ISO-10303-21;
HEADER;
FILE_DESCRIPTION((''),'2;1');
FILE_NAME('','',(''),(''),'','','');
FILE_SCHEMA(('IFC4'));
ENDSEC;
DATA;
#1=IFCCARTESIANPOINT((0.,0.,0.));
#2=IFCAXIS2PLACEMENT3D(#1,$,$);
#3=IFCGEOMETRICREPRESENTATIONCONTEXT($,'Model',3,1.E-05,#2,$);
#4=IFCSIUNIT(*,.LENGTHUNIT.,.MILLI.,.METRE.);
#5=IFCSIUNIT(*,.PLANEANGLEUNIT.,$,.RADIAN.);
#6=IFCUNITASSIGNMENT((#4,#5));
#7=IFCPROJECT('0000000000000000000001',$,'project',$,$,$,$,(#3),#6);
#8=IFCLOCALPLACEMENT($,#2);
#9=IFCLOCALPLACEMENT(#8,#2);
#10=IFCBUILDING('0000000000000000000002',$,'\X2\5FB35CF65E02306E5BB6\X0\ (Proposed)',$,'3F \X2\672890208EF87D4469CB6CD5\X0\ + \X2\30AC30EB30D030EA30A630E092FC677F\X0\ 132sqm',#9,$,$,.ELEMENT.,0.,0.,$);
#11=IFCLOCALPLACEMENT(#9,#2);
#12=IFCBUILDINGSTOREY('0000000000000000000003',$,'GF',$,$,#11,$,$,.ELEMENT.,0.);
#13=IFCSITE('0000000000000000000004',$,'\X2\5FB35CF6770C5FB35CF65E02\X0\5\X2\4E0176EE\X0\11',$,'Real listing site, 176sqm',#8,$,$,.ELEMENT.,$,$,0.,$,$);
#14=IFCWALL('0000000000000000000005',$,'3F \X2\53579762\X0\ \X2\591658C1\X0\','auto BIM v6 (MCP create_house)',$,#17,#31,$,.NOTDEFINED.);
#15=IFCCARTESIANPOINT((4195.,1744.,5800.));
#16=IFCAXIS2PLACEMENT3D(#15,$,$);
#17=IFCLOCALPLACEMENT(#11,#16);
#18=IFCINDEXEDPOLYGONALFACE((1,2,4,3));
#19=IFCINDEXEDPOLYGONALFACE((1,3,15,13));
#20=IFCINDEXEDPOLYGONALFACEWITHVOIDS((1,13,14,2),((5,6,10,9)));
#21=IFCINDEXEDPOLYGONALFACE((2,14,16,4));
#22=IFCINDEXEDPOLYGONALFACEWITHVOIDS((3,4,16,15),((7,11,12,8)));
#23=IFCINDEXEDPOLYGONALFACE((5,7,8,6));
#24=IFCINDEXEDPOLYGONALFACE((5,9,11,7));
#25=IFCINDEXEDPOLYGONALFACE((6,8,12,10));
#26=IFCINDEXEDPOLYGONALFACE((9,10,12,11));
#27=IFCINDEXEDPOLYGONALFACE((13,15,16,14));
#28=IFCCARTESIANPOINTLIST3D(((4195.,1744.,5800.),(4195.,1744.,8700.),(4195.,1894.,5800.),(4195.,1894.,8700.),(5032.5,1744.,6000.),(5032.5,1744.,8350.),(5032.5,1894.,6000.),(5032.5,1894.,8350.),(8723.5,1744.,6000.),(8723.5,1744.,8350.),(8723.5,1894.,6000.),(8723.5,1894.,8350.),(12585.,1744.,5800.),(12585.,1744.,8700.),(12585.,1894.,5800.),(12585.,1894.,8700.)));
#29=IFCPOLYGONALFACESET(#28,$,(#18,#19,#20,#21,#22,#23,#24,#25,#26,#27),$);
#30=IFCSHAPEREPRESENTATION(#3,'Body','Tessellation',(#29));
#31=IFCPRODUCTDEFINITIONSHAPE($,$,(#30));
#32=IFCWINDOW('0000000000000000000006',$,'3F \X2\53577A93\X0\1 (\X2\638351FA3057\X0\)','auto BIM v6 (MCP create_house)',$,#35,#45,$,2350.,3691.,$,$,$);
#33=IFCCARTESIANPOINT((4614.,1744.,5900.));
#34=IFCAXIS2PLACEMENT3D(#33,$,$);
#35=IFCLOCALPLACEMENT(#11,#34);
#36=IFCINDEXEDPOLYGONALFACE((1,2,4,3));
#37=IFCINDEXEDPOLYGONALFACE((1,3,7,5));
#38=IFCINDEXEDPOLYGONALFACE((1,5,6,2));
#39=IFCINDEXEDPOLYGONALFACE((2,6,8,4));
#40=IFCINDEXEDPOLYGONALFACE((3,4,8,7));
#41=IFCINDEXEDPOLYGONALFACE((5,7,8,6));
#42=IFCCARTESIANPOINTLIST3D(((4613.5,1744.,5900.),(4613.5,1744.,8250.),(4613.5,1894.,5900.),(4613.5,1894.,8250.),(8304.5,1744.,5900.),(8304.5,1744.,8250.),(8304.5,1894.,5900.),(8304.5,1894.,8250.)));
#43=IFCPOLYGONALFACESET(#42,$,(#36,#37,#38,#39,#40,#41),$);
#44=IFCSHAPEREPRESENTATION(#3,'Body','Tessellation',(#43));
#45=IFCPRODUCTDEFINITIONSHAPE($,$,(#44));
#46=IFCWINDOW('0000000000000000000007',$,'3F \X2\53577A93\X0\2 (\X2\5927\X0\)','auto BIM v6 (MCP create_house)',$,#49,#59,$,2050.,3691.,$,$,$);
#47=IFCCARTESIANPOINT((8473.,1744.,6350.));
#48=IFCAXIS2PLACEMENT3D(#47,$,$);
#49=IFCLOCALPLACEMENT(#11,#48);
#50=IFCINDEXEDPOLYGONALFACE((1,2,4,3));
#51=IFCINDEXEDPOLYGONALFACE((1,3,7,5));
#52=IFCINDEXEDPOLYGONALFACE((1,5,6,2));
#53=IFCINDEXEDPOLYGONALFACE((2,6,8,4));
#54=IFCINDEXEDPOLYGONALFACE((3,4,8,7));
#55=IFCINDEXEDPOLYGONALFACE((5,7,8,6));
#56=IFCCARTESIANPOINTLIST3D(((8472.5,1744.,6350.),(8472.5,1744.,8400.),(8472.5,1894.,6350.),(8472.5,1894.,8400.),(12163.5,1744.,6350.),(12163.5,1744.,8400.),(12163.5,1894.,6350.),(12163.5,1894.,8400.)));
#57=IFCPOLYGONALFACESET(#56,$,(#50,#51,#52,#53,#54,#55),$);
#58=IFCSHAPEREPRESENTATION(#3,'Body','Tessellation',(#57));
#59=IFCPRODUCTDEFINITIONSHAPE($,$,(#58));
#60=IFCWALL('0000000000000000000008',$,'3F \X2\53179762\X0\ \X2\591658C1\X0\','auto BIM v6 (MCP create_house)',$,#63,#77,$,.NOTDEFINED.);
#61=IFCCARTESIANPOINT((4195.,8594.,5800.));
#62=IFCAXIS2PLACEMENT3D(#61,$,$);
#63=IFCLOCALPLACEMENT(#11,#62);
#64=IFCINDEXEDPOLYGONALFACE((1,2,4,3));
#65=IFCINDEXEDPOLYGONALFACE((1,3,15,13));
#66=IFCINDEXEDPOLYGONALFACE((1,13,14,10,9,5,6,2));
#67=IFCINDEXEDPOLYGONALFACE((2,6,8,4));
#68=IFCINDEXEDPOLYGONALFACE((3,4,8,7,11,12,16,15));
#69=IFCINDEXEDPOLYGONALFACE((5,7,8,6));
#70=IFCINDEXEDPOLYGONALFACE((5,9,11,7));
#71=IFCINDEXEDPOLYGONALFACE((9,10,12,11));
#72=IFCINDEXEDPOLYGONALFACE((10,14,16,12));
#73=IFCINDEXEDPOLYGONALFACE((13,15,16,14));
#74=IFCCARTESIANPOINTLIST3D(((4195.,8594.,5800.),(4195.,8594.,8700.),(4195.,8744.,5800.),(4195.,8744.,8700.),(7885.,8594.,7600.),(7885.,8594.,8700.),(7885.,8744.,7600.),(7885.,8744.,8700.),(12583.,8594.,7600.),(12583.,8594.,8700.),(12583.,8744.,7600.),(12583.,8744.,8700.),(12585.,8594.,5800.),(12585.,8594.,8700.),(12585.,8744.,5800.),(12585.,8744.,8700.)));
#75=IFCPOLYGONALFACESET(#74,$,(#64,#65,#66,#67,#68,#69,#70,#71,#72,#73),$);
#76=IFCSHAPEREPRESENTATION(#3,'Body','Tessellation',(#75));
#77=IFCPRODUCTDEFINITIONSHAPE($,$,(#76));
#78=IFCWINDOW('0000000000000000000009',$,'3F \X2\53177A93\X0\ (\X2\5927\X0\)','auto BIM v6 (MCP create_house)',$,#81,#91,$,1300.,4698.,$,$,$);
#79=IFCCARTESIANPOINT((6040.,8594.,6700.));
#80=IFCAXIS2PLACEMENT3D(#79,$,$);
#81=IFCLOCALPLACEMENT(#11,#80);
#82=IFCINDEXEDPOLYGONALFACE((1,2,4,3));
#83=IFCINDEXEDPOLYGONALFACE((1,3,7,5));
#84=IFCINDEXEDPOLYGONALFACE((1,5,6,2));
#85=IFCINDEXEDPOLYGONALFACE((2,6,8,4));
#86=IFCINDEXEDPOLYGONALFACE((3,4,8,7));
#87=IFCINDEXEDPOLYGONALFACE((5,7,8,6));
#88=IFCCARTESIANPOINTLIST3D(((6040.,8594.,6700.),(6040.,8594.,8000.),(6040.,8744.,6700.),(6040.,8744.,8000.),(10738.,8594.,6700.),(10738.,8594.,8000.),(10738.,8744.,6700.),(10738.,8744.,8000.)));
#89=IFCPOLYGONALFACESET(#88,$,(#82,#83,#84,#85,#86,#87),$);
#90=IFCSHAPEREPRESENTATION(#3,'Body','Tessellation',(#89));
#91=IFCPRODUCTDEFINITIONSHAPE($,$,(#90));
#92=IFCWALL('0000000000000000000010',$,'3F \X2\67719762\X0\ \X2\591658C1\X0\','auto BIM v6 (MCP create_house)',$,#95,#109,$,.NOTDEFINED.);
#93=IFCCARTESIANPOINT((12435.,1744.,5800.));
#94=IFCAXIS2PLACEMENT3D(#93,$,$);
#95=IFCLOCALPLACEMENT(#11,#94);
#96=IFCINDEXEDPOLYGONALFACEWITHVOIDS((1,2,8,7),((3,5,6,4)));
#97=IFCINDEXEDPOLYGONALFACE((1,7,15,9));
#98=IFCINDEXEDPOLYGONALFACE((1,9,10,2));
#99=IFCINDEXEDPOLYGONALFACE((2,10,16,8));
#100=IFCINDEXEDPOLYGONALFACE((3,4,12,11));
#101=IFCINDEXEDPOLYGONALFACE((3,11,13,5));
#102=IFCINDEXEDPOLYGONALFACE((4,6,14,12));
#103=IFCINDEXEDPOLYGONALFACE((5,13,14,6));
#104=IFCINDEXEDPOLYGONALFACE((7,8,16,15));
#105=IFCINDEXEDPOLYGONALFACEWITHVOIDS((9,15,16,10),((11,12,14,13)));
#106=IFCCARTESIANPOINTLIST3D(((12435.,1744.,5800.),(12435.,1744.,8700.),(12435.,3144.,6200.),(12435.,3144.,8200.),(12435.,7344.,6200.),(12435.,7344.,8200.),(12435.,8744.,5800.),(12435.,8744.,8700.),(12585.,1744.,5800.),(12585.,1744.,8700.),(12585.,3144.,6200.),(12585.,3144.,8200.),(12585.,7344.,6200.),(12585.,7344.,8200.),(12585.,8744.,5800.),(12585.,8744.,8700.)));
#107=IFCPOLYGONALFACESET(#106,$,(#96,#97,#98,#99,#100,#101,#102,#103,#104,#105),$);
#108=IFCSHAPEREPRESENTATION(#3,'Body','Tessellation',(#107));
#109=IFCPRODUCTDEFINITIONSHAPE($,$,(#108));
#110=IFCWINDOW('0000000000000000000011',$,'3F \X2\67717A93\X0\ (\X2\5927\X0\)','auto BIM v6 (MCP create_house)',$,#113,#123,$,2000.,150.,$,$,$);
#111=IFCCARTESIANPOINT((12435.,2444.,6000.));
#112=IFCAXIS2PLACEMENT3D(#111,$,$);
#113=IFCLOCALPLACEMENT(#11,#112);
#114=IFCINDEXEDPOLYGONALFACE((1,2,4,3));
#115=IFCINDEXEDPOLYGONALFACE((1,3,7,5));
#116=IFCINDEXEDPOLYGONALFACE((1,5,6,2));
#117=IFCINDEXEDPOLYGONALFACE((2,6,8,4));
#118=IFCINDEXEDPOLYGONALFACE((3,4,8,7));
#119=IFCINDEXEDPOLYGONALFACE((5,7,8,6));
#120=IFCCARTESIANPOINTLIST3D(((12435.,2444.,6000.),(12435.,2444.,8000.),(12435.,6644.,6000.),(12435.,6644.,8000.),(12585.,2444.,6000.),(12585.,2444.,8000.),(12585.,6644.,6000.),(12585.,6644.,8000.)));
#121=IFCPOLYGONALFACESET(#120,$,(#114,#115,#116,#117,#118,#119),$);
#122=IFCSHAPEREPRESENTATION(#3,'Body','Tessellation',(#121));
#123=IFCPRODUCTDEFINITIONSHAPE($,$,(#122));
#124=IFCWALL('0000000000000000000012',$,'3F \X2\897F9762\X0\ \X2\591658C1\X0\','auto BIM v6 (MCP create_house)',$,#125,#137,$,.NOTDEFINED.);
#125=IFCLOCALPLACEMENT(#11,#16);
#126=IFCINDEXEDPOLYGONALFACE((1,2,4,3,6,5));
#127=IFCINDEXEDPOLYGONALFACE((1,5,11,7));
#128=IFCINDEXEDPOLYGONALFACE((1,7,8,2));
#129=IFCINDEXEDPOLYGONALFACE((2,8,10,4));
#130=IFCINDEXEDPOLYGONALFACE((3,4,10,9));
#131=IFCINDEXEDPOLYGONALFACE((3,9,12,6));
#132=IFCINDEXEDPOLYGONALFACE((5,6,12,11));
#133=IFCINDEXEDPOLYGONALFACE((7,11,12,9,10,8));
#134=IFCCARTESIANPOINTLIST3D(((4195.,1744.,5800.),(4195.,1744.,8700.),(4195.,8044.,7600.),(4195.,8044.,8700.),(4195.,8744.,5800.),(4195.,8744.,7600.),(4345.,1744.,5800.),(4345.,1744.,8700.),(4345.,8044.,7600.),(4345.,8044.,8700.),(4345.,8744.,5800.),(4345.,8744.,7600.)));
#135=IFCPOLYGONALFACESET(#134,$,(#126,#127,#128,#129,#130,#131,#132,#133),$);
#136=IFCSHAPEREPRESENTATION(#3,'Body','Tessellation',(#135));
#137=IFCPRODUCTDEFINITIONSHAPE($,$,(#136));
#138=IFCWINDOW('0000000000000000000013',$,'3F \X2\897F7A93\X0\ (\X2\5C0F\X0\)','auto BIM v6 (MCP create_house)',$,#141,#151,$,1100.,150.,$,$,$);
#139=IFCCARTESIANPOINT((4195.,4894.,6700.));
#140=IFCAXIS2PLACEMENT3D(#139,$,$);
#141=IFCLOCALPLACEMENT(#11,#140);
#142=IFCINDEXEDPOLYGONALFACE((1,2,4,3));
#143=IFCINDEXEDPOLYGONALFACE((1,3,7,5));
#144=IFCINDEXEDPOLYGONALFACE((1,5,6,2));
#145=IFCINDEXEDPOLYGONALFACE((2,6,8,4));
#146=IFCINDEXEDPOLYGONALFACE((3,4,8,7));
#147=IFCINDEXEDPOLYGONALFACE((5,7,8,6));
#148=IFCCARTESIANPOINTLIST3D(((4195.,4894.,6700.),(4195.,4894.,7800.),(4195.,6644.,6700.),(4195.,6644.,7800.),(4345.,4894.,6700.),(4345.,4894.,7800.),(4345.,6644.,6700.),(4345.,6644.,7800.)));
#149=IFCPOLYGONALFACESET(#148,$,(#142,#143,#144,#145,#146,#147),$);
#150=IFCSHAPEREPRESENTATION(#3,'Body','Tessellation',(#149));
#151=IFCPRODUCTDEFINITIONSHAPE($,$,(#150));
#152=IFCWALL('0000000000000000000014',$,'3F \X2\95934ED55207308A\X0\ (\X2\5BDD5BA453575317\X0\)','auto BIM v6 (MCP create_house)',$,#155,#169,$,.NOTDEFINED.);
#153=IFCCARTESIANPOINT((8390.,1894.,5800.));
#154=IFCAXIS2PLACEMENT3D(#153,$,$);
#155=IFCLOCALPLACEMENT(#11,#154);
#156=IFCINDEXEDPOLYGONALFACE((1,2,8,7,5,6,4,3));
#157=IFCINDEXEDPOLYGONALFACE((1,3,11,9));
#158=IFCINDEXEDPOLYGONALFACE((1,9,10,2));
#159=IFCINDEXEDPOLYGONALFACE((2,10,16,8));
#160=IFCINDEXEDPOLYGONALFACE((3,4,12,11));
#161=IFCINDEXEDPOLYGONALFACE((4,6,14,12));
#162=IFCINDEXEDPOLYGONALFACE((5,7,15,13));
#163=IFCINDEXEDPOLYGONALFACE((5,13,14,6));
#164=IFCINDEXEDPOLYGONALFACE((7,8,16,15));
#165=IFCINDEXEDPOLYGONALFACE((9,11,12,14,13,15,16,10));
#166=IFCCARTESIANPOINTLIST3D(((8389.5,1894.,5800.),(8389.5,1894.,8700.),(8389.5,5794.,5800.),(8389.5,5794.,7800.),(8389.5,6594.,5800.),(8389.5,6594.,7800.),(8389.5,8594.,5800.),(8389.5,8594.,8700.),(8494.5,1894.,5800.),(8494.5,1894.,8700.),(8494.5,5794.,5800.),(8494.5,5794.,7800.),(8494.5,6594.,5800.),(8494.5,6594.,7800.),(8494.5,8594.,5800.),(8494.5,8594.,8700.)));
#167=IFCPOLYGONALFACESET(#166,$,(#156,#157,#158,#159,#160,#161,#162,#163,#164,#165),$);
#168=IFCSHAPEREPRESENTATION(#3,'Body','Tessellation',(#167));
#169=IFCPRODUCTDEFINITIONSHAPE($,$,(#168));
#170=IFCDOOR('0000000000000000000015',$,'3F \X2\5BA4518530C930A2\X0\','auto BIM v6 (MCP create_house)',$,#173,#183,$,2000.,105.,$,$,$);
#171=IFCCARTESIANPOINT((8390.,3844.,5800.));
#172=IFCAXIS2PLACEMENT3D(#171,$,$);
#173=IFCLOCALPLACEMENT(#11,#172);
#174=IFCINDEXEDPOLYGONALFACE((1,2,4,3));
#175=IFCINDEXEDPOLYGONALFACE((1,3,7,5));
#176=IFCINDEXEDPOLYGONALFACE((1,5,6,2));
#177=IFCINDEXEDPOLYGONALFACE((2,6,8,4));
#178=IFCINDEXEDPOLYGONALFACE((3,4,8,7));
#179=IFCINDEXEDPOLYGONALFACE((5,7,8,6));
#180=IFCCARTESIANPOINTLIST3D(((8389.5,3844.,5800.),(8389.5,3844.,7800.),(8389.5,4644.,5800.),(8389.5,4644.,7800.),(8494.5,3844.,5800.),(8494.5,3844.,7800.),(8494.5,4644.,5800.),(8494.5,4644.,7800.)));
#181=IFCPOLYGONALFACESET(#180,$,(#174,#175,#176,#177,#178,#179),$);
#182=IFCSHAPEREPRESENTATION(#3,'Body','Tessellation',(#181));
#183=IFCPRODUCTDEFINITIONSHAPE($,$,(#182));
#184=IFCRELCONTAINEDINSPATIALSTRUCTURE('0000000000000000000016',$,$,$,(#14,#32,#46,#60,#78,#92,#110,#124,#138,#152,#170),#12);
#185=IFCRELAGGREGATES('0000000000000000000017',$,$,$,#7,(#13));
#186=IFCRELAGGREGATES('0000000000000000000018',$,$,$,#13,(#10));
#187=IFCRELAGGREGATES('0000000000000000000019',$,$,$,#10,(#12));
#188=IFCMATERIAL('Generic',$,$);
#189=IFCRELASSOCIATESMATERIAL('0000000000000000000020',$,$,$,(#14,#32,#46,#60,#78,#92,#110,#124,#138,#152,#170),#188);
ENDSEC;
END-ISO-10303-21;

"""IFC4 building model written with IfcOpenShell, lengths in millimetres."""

from ifc_helpers import new_model, si_unit, frame, frame_2d, origin, place, context, project, spatial, rectangle, extrude, material, element, fill, save


model = new_model("IFC4")

# Units and contexts
model_context = context("Model", 3, precision=1e-05, world=origin())
ifc_project = project(units=[si_unit("LENGTHUNIT", "METRE", prefix="MILLI"), si_unit("PLANEANGLEUNIT", "RADIAN")], contexts=[model_context])

# Site, building, storey
site_placement = place(None, origin())
site = spatial("IfcSite", under=ifc_project, at=site_placement, Name="徳島県徳島市5丁目11", ObjectType="Real listing site, 176sqm", CompositionType="ELEMENT", RefElevation=0.0)
building_placement = place(site_placement, origin())
building = spatial("IfcBuilding", under=site, at=building_placement, Name="徳島市の家 (Proposed)", ObjectType="3F 木造軸組構法 + ガルバリウム鋼板 132sqm", CompositionType="ELEMENT", ElevationOfRefHeight=0.0, ElevationOfTerrain=0.0)
storey_placement = place(building_placement, origin())
storey = spatial("IfcBuildingStorey", under=building, at=storey_placement, Name="GF", CompositionType="ELEMENT", Elevation=0.0)

# Shared definitions
ifc_material = material(Name="Generic")

# Wall, openings, windows
wall_1_placement = place(storey_placement, frame((4195.0, 1744.0, 5800.0)))
wall_1 = element("IfcWall", 1, at=wall_1_placement, inside=storey, material=ifc_material, Name="3F 南面 外壁", Description="auto BIM v6 (MCP create_house)", PredefinedType="NOTDEFINED", context=model_context, shape_type="SweptSolid", body=[
    extrude(rectangle(XDim=8390.0, YDim=150.0, at=frame_2d((4195.0, 75.0))), frame((4195.0, 1744.0, 5800.0)), (0.0, 0.0, 1.0), 2900.0),
])
opening_1_placement = place(storey_placement, frame((4614.0, 1744.0, 5900.0)))
opening_1 = element("IfcOpeningElement", 2, at=opening_1_placement, cuts=wall_1, PredefinedType="NOTDEFINED", context=model_context, shape_type="SweptSolid", body=[
    extrude(rectangle(XDim=3691.0, YDim=150.0, at=frame_2d((1845.0, 75.0))), frame((4614.0, 1744.0, 5900.0)), (0.0, 0.0, 1.0), 2350.0),
])
opening_2_placement = place(storey_placement, frame((8473.0, 1744.0, 6350.0)))
opening_2 = element("IfcOpeningElement", 3, at=opening_2_placement, cuts=wall_1, PredefinedType="NOTDEFINED", context=model_context, shape_type="SweptSolid", body=[
    extrude(rectangle(XDim=3691.0, YDim=150.0, at=frame_2d((1845.0, 75.0))), frame((8473.0, 1744.0, 6350.0)), (0.0, 0.0, 1.0), 2050.0),
])
window_1_placement = place(storey_placement, frame((4614.0, 1744.0, 5900.0)))
window_1 = element("IfcWindow", 4, at=window_1_placement, inside=storey, material=ifc_material, Name="3F 南窓1 (掃出し)", Description="auto BIM v6 (MCP create_house)", OverallHeight=2350.0, OverallWidth=3691.0, context=model_context, shape_type="SweptSolid", body=[
    extrude(rectangle(XDim=3691.0, YDim=150.0, at=frame_2d((1845.0, 75.0))), frame((4614.0, 1744.0, 5900.0)), (0.0, 0.0, 1.0), 2350.0),
])
fill(opening_1, window_1)
window_2_placement = place(storey_placement, frame((8473.0, 1744.0, 6350.0)))
window_2 = element("IfcWindow", 5, at=window_2_placement, inside=storey, material=ifc_material, Name="3F 南窓2 (大)", Description="auto BIM v6 (MCP create_house)", OverallHeight=2050.0, OverallWidth=3691.0, context=model_context, shape_type="SweptSolid", body=[
    extrude(rectangle(XDim=3691.0, YDim=150.0, at=frame_2d((1845.0, 75.0))), frame((8473.0, 1744.0, 6350.0)), (0.0, 0.0, 1.0), 2050.0),
])
fill(opening_2, window_2)

# Walls, openings, windows
wall_2_placement = place(storey_placement, frame((4195.0, 8594.0, 5800.0)))
wall_2 = element("IfcWall", 6, at=wall_2_placement, inside=storey, material=ifc_material, Name="3F 北面 外壁", Description="auto BIM v6 (MCP create_house)", PredefinedType="NOTDEFINED", context=model_context, shape_type="SweptSolid", body=[
    extrude(rectangle(XDim=8390.0, YDim=150.0, at=frame_2d((4195.0, 75.0))), frame((4195.0, 8594.0, 5800.0)), (0.0, 0.0, 1.0), 2900.0),
])
opening_3_placement = place(storey_placement, frame((6040.0, 8594.0, 6700.0)))
opening_3 = element("IfcOpeningElement", 7, at=opening_3_placement, cuts=wall_2, PredefinedType="NOTDEFINED", context=model_context, shape_type="SweptSolid", body=[
    extrude(rectangle(XDim=4698.0, YDim=150.0, at=frame_2d((2349.0, 75.0))), frame((6040.0, 8594.0, 6700.0)), (0.0, 0.0, 1.0), 1300.0),
])
window_3_placement = place(storey_placement, frame((6040.0, 8594.0, 6700.0)))
window_3 = element("IfcWindow", 8, at=window_3_placement, inside=storey, material=ifc_material, Name="3F 北窓 (大)", Description="auto BIM v6 (MCP create_house)", OverallHeight=1300.0, OverallWidth=4698.0, context=model_context, shape_type="SweptSolid", body=[
    extrude(rectangle(XDim=4698.0, YDim=150.0, at=frame_2d((2349.0, 75.0))), frame((6040.0, 8594.0, 6700.0)), (0.0, 0.0, 1.0), 1300.0),
])
fill(opening_3, window_3)
wall_3_placement = place(storey_placement, frame((12435.0, 1744.0, 5800.0)))
wall_3 = element("IfcWall", 9, at=wall_3_placement, inside=storey, material=ifc_material, Name="3F 東面 外壁", Description="auto BIM v6 (MCP create_house)", PredefinedType="NOTDEFINED", context=model_context, shape_type="SweptSolid", body=[
    extrude(rectangle(XDim=150.0, YDim=7000.0, at=frame_2d((75.0, 3500.0))), frame((12435.0, 1744.0, 5800.0)), (0.0, 0.0, 1.0), 2900.0),
])
opening_4_placement = place(storey_placement, frame((12435.0, 2444.0, 6000.0)))
opening_4 = element("IfcOpeningElement", 10, at=opening_4_placement, cuts=wall_3, PredefinedType="NOTDEFINED", context=model_context, shape_type="SweptSolid", body=[
    extrude(rectangle(XDim=150.0, YDim=4200.0, at=frame_2d((75.0, 2100.0))), frame((12435.0, 2444.0, 6000.0)), (0.0, 0.0, 1.0), 2000.0),
])
window_4_placement = place(storey_placement, frame((12435.0, 2444.0, 6000.0)))
window_4 = element("IfcWindow", 11, at=window_4_placement, inside=storey, material=ifc_material, Name="3F 東窓 (大)", Description="auto BIM v6 (MCP create_house)", OverallHeight=2000.0, OverallWidth=150.0, context=model_context, shape_type="SweptSolid", body=[
    extrude(rectangle(XDim=150.0, YDim=4200.0, at=frame_2d((75.0, 2100.0))), frame((12435.0, 2444.0, 6000.0)), (0.0, 0.0, 1.0), 2000.0),
])
fill(opening_4, window_4)
wall_4_placement = place(storey_placement, frame((4195.0, 1744.0, 5800.0)))
wall_4 = element("IfcWall", 12, at=wall_4_placement, inside=storey, material=ifc_material, Name="3F 西面 外壁", Description="auto BIM v6 (MCP create_house)", PredefinedType="NOTDEFINED", context=model_context, shape_type="SweptSolid", body=[
    extrude(rectangle(XDim=150.0, YDim=7000.0, at=frame_2d((75.0, 3500.0))), frame((4195.0, 1744.0, 5800.0)), (0.0, 0.0, 1.0), 2900.0),
])
opening_5_placement = place(storey_placement, frame((4195.0, 4894.0, 6700.0)))
opening_5 = element("IfcOpeningElement", 13, at=opening_5_placement, cuts=wall_4, PredefinedType="NOTDEFINED", context=model_context, shape_type="SweptSolid", body=[
    extrude(rectangle(XDim=150.0, YDim=1750.0, at=frame_2d((75.0, 875.0))), frame((4195.0, 4894.0, 6700.0)), (0.0, 0.0, 1.0), 1100.0),
])
window_5_placement = place(storey_placement, frame((4195.0, 4894.0, 6700.0)))
window_5 = element("IfcWindow", 14, at=window_5_placement, inside=storey, material=ifc_material, Name="3F 西窓 (小)", Description="auto BIM v6 (MCP create_house)", OverallHeight=1100.0, OverallWidth=150.0, context=model_context, shape_type="SweptSolid", body=[
    extrude(rectangle(XDim=150.0, YDim=1750.0, at=frame_2d((75.0, 875.0))), frame((4195.0, 4894.0, 6700.0)), (0.0, 0.0, 1.0), 1100.0),
])
fill(opening_5, window_5)

# Wall, opening, door
wall_5_placement = place(storey_placement, frame((8390.0, 1894.0, 5800.0)))
wall_5 = element("IfcWall", 15, at=wall_5_placement, inside=storey, material=ifc_material, Name="3F 間仕切り (寝室南北)", Description="auto BIM v6 (MCP create_house)", PredefinedType="NOTDEFINED", context=model_context, shape_type="SweptSolid", body=[
    extrude(rectangle(XDim=105.0, YDim=6700.0, at=frame_2d((52.0, 3350.0))), frame((8390.0, 1894.0, 5800.0)), (0.0, 0.0, 1.0), 2900.0),
])
opening_6_placement = place(storey_placement, frame((8390.0, 3844.0, 5800.0)))
opening_6 = element("IfcOpeningElement", 16, at=opening_6_placement, cuts=wall_5, PredefinedType="NOTDEFINED", context=model_context, shape_type="SweptSolid", body=[
    extrude(rectangle(XDim=105.0, YDim=800.0, at=frame_2d((52.0, 400.0))), frame((8390.0, 3844.0, 5800.0)), (0.0, 0.0, 1.0), 2000.0),
])
door_1_placement = place(storey_placement, frame((8390.0, 3844.0, 5800.0)))
door_1 = element("IfcDoor", 17, at=door_1_placement, inside=storey, material=ifc_material, Name="3F 室内ドア", Description="auto BIM v6 (MCP create_house)", OverallHeight=2000.0, OverallWidth=105.0, context=model_context, shape_type="SweptSolid", body=[
    extrude(rectangle(XDim=105.0, YDim=800.0, at=frame_2d((52.0, 400.0))), frame((8390.0, 3844.0, 5800.0)), (0.0, 0.0, 1.0), 2000.0),
])
fill(opening_6, door_1)

save(model, "model.ifc")
